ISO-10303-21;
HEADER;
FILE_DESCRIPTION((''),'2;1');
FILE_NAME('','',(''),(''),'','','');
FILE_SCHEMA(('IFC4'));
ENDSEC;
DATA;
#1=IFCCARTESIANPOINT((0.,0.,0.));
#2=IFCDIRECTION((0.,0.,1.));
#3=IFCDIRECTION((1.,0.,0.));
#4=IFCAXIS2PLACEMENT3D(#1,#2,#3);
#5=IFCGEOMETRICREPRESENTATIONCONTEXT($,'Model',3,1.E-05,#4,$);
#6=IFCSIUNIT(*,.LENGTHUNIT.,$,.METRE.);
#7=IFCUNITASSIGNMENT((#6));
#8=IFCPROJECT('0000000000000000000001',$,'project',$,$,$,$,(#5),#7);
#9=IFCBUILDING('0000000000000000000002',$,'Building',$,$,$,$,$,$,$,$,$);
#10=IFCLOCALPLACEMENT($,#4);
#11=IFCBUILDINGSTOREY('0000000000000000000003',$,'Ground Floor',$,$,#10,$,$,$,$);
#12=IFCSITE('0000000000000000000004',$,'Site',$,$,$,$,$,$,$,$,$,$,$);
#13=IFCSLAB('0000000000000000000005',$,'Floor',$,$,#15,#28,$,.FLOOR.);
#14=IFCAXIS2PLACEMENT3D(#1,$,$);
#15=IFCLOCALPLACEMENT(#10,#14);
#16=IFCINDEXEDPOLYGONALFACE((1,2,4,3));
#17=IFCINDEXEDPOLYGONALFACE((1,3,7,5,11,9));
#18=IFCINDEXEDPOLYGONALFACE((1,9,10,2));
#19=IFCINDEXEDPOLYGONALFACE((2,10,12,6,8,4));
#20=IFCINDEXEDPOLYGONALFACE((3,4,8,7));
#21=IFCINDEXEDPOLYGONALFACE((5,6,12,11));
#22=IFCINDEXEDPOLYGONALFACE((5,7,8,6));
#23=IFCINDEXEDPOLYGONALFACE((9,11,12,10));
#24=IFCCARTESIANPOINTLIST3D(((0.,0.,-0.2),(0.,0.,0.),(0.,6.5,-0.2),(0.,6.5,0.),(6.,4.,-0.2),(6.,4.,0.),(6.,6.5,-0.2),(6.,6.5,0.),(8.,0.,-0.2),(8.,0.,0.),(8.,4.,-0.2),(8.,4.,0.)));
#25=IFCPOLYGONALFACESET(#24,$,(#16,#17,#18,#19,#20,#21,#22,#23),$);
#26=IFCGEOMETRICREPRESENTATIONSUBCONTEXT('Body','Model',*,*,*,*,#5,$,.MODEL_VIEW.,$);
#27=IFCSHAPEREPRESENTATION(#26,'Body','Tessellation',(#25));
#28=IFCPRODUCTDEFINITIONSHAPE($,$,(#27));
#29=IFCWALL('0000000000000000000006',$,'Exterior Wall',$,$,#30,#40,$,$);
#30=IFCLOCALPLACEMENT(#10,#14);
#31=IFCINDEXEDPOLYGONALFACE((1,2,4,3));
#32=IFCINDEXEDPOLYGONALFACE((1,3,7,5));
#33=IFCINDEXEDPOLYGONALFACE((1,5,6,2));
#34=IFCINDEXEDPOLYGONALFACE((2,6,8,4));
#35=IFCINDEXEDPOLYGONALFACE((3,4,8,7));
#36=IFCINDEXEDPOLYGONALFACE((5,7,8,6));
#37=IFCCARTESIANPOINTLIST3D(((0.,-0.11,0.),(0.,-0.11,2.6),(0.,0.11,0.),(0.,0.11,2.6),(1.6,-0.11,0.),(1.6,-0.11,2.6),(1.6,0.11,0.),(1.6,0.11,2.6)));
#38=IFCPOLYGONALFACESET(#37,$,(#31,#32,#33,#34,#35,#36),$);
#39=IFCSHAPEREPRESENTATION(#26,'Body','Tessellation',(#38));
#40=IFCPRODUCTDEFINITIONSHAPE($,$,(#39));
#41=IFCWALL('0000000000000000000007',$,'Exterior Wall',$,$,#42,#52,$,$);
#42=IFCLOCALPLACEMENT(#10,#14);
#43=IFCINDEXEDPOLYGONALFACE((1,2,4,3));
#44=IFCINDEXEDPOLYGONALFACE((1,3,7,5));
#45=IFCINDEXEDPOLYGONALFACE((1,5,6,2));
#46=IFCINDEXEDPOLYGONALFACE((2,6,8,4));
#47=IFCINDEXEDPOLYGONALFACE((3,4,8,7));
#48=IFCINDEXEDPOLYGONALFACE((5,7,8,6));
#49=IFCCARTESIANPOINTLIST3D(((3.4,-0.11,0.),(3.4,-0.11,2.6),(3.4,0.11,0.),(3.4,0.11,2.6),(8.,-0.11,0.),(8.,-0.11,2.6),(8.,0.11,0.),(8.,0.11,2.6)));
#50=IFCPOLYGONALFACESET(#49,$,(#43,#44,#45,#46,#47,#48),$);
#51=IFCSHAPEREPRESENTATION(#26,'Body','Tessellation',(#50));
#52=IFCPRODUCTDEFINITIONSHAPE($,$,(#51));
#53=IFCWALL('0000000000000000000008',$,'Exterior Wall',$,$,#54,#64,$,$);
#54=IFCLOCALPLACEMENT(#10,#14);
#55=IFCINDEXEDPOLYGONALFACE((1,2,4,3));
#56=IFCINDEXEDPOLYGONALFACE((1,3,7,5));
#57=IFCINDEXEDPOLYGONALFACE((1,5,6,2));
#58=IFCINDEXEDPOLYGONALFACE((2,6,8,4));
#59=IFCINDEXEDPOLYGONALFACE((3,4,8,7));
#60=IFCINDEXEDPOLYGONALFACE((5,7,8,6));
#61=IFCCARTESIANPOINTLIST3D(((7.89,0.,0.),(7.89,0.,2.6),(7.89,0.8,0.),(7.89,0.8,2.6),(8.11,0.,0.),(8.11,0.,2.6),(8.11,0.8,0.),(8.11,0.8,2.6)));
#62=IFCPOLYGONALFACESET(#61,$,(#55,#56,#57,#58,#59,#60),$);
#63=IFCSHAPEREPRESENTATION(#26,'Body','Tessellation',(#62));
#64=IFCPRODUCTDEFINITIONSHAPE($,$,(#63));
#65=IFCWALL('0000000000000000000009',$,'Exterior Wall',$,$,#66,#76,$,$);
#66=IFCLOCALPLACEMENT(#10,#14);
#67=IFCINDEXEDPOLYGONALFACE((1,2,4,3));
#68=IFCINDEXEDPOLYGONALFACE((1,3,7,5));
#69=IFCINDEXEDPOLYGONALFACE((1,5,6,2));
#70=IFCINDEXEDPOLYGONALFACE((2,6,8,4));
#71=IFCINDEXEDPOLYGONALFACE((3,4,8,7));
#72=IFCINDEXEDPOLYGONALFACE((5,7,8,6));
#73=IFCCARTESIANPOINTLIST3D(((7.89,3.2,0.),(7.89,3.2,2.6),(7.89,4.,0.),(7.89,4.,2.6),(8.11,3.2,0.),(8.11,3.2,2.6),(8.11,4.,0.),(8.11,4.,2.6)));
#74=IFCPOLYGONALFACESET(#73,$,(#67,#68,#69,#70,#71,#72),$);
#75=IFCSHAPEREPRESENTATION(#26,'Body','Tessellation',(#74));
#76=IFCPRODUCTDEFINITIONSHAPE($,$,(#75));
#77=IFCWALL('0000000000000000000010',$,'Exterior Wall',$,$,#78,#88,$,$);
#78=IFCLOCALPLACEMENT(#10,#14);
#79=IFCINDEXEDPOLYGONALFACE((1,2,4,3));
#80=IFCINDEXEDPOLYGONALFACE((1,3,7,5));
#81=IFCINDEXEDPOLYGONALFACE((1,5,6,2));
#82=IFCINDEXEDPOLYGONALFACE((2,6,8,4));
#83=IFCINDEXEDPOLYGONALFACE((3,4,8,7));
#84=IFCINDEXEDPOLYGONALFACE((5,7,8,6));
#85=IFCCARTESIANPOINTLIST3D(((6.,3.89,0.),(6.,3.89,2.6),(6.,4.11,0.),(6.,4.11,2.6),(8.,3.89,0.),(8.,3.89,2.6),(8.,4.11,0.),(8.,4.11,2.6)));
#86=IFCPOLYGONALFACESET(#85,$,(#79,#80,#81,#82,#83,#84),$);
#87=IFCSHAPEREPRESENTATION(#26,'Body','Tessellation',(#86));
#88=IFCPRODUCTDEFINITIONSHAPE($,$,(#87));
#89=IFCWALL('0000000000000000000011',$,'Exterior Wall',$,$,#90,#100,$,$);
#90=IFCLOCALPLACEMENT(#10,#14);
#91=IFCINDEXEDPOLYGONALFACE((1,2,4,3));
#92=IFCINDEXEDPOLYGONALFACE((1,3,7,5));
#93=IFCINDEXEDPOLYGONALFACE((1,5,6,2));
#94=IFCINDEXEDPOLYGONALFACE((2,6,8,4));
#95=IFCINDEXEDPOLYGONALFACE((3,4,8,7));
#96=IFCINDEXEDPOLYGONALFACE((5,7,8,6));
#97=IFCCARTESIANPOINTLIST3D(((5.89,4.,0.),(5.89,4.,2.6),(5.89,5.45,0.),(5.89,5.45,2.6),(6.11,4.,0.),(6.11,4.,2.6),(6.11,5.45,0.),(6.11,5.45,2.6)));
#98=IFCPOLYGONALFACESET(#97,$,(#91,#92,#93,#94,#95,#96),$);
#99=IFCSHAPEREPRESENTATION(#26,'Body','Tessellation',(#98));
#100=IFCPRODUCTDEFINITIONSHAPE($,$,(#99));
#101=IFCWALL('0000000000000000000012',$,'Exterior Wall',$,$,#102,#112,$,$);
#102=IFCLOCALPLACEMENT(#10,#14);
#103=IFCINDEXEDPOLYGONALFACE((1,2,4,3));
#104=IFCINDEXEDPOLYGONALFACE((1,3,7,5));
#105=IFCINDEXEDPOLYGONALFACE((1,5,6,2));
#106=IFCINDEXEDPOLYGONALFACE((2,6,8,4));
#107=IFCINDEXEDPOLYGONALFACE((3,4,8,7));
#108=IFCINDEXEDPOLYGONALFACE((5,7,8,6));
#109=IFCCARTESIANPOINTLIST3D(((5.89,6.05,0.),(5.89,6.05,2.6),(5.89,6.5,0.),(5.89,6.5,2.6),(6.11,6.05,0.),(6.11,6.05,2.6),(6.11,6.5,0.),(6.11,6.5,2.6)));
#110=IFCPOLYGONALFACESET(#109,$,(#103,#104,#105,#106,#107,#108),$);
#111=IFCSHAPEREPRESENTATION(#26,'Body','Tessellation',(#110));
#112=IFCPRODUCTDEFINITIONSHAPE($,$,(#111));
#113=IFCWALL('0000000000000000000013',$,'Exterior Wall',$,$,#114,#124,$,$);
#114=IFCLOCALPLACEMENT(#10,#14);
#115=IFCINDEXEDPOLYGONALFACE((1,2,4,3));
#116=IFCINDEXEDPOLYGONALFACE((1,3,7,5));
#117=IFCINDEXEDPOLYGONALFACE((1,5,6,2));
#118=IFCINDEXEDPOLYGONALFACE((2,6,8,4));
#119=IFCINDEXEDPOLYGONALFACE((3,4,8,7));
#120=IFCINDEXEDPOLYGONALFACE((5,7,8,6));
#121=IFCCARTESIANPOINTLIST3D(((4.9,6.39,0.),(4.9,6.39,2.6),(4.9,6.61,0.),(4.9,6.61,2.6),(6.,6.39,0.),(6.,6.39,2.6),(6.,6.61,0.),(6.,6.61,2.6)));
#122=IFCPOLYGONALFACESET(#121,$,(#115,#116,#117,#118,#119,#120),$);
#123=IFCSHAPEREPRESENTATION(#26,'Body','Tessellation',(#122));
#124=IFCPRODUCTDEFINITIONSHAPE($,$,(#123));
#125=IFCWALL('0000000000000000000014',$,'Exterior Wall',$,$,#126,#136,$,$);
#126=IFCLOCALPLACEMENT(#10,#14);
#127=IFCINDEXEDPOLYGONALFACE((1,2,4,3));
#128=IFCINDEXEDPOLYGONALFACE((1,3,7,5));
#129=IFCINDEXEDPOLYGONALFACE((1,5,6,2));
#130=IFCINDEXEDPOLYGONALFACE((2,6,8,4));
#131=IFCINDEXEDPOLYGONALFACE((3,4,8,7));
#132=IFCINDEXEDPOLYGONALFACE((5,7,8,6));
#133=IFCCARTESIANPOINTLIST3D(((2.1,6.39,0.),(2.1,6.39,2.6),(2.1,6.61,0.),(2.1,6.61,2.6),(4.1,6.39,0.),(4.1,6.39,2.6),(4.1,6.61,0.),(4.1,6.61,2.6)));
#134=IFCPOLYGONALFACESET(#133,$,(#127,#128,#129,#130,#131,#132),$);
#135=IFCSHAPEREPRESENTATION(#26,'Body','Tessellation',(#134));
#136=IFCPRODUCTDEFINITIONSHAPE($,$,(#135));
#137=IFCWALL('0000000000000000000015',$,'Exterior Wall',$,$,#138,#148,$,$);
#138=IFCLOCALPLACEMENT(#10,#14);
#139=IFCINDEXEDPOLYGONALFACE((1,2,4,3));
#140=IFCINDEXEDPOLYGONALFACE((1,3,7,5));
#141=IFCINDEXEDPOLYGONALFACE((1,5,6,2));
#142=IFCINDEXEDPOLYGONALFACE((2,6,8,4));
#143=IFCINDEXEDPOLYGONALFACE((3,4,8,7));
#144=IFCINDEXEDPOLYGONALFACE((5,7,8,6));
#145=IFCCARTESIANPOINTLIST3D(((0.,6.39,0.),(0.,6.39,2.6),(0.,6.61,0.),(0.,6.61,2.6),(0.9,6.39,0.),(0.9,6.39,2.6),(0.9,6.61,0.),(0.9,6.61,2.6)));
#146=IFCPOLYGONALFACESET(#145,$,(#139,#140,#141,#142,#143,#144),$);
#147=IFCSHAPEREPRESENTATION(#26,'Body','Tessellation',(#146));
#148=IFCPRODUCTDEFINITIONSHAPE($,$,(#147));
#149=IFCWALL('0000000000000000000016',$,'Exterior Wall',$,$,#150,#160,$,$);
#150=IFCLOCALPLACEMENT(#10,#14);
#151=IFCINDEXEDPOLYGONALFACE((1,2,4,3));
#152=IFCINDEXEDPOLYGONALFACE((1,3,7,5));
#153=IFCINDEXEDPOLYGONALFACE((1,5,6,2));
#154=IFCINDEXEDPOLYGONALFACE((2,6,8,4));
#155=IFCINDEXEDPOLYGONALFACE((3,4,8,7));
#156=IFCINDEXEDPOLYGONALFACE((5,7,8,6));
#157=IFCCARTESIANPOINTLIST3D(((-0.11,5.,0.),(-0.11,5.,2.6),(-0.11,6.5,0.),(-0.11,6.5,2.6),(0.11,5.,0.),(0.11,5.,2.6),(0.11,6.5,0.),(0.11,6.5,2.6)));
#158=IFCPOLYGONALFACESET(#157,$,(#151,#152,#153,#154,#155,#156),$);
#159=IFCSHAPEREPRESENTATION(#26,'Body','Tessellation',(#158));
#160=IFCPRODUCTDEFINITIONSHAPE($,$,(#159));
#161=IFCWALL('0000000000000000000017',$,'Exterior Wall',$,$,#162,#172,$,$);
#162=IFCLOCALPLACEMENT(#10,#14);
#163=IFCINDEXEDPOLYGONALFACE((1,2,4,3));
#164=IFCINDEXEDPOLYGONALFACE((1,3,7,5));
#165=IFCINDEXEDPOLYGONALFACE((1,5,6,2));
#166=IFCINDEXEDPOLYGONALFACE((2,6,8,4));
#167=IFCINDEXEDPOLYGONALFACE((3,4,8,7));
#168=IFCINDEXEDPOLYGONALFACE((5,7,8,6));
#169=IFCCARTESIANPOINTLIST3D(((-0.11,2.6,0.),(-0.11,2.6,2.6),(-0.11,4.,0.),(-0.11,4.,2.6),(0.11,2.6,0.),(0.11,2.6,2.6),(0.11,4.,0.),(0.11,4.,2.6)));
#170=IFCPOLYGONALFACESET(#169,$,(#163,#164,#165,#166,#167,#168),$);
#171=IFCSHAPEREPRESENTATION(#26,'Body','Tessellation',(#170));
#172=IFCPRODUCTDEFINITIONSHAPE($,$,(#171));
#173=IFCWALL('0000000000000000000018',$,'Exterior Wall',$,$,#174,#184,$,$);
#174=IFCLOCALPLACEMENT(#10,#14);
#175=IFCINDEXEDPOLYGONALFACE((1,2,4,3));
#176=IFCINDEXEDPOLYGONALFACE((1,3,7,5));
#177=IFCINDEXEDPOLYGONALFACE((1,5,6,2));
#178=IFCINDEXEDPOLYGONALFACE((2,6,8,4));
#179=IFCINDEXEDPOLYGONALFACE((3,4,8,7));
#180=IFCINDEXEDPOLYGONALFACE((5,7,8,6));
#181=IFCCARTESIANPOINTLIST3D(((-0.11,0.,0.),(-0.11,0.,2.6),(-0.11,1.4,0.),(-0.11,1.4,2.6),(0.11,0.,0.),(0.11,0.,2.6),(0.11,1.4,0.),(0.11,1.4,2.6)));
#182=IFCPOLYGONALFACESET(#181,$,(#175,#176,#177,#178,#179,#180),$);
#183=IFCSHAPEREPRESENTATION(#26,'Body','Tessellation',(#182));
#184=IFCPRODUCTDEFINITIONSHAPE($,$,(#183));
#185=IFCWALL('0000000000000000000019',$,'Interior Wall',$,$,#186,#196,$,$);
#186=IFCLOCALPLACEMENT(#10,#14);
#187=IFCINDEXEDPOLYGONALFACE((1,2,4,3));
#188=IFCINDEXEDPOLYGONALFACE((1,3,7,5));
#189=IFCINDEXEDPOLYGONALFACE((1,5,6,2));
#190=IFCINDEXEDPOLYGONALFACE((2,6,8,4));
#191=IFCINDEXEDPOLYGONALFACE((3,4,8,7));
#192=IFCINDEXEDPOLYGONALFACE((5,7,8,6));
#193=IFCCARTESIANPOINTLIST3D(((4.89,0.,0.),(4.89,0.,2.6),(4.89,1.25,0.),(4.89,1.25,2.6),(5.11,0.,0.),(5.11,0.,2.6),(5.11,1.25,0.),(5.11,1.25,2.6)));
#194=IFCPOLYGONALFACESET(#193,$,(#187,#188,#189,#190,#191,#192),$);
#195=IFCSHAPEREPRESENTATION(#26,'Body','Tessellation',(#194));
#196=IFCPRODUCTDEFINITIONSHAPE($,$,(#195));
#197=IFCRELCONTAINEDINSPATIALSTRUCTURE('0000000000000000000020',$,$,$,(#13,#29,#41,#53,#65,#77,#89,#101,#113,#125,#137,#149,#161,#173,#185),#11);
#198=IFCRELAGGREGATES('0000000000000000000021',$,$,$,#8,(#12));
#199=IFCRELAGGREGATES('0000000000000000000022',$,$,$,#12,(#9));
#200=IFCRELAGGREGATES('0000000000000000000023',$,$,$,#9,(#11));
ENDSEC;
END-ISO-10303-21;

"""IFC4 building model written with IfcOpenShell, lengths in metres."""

from ifc_helpers import new_model, si_unit, frame, origin_with_axes, place, context, subcontext, project, spatial, indexed_curve, outline, extrude, element, save


model = new_model("IFC4")

# Units and contexts
model_context = context("Model", 3, precision=1e-05, world=origin_with_axes())
body_context = subcontext(model_context, "Body", "Model", "MODEL_VIEW")
ifc_project = project(units=[si_unit("LENGTHUNIT", "METRE")], contexts=[model_context])

# Site, building, storey
site = spatial("IfcSite", under=ifc_project, Name="Site")
building = spatial("IfcBuilding", under=site, Name="Building")
storey_placement = place(None, origin_with_axes())
storey = spatial("IfcBuildingStorey", under=building, at=storey_placement, Name="Ground Floor")

# Slab
slab_placement = place(storey_placement, frame((0.0, 0.0, -0.2), z_axis=(0.0, 0.0, 1.0), x_axis=(1.0, 0.0, 0.0)))
element("IfcSlab", 1, at=slab_placement, inside=storey, Name="Floor", PredefinedType="FLOOR", context=body_context, shape_type="SweptSolid", body=[
    extrude(outline(indexed_curve([(0.0, 0.0), (8.0, 0.0), (8.0, 4.0), (6.0, 4.0), (6.0, 6.5), (0.0, 6.5)])), None, (0.0, 0.0, 1.0), 0.2),
])

# Walls
wall_1_placement = place(storey_placement, origin_with_axes())
element("IfcWall", 2, at=wall_1_placement, inside=storey, Name="Exterior Wall", context=body_context, shape_type="SweptSolid", body=[
    extrude(outline(indexed_curve([(0.0, 0.0), (0.0, 0.22), (1.6, 0.22), (1.6, 0.0), (0.0, 0.0)], self_intersect=False)), frame((0.0, -0.11, 0.0), z_axis=(0.0, 0.0, 1.0), x_axis=(1.0, 0.0, 0.0)), (0.0, 0.0, 1.0), 2.6),
])
wall_2_placement = place(storey_placement, frame((3.4, 0.0, 0.0), z_axis=(0.0, 0.0, 1.0), x_axis=(1.0, 0.0, 0.0)))
element("IfcWall", 3, at=wall_2_placement, inside=storey, Name="Exterior Wall", context=body_context, shape_type="SweptSolid", body=[
    extrude(outline(indexed_curve([(0.0, 0.0), (0.0, 0.22), (4.6, 0.22), (4.6, 0.0), (0.0, 0.0)], self_intersect=False)), frame((0.0, -0.11, 0.0), z_axis=(0.0, 0.0, 1.0), x_axis=(1.0, 0.0, 0.0)), (0.0, 0.0, 1.0), 2.6),
])
wall_3_placement = place(storey_placement, frame((8.0, 0.0, 0.0), z_axis=(0.0, 0.0, 1.0), x_axis=(0.0, 1.0, 0.0)))
element("IfcWall", 4, at=wall_3_placement, inside=storey, Name="Exterior Wall", context=body_context, shape_type="SweptSolid", body=[
    extrude(outline(indexed_curve([(0.0, 0.0), (0.0, 0.22), (0.8, 0.22), (0.8, 0.0), (0.0, 0.0)], self_intersect=False)), frame((0.0, -0.11, 0.0), z_axis=(0.0, 0.0, 1.0), x_axis=(1.0, 0.0, 0.0)), (0.0, 0.0, 1.0), 2.6),
])
wall_4_placement = place(storey_placement, frame((8.0, 3.2, 0.0), z_axis=(0.0, 0.0, 1.0), x_axis=(0.0, 1.0, 0.0)))
element("IfcWall", 5, at=wall_4_placement, inside=storey, Name="Exterior Wall", context=body_context, shape_type="SweptSolid", body=[
    extrude(outline(indexed_curve([(0.0, 0.0), (0.0, 0.22), (0.8, 0.22), (0.8, 0.0), (0.0, 0.0)], self_intersect=False)), frame((0.0, -0.11, 0.0), z_axis=(0.0, 0.0, 1.0), x_axis=(1.0, 0.0, 0.0)), (0.0, 0.0, 1.0), 2.6),
])
wall_5_placement = place(storey_placement, frame((8.0, 4.0, 0.0), z_axis=(0.0, 0.0, 1.0), x_axis=(-1.0, 0.0, 0.0)))
element("IfcWall", 6, at=wall_5_placement, inside=storey, Name="Exterior Wall", context=body_context, shape_type="SweptSolid", body=[
    extrude(outline(indexed_curve([(0.0, 0.0), (0.0, 0.22), (2.0, 0.22), (2.0, 0.0), (0.0, 0.0)], self_intersect=False)), frame((0.0, -0.11, 0.0), z_axis=(0.0, 0.0, 1.0), x_axis=(1.0, 0.0, 0.0)), (0.0, 0.0, 1.0), 2.6),
])
wall_6_placement = place(storey_placement, frame((6.0, 4.0, 0.0), z_axis=(0.0, 0.0, 1.0), x_axis=(0.0, 1.0, 0.0)))
element("IfcWall", 7, at=wall_6_placement, inside=storey, Name="Exterior Wall", context=body_context, shape_type="SweptSolid", body=[
    extrude(outline(indexed_curve([(0.0, 0.0), (0.0, 0.22), (1.45, 0.22), (1.45, 0.0), (0.0, 0.0)], self_intersect=False)), frame((0.0, -0.11, 0.0), z_axis=(0.0, 0.0, 1.0), x_axis=(1.0, 0.0, 0.0)), (0.0, 0.0, 1.0), 2.6),
])
wall_7_placement = place(storey_placement, frame((6.0, 6.05, 0.0), z_axis=(0.0, 0.0, 1.0), x_axis=(0.0, 1.0, 0.0)))
element("IfcWall", 8, at=wall_7_placement, inside=storey, Name="Exterior Wall", context=body_context, shape_type="SweptSolid", body=[
    extrude(outline(indexed_curve([(0.0, 0.0), (0.0, 0.22), (0.45, 0.22), (0.45, 0.0), (0.0, 0.0)], self_intersect=False)), frame((0.0, -0.11, 0.0), z_axis=(0.0, 0.0, 1.0), x_axis=(1.0, 0.0, 0.0)), (0.0, 0.0, 1.0), 2.6),
])
wall_8_placement = place(storey_placement, frame((6.0, 6.5, 0.0), z_axis=(0.0, 0.0, 1.0), x_axis=(-1.0, 0.0, 0.0)))
element("IfcWall", 9, at=wall_8_placement, inside=storey, Name="Exterior Wall", context=body_context, shape_type="SweptSolid", body=[
    extrude(outline(indexed_curve([(0.0, 0.0), (0.0, 0.22), (1.1, 0.22), (1.1, 0.0), (0.0, 0.0)], self_intersect=False)), frame((0.0, -0.11, 0.0), z_axis=(0.0, 0.0, 1.0), x_axis=(1.0, 0.0, 0.0)), (0.0, 0.0, 1.0), 2.6),
])
wall_9_placement = place(storey_placement, frame((4.1, 6.5, 0.0), z_axis=(0.0, 0.0, 1.0), x_axis=(-1.0, 0.0, 0.0)))
element("IfcWall", 10, at=wall_9_placement, inside=storey, Name="Exterior Wall", context=body_context, shape_type="SweptSolid", body=[
    extrude(outline(indexed_curve([(0.0, 0.0), (0.0, 0.22), (2.0, 0.22), (2.0, 0.0), (0.0, 0.0)], self_intersect=False)), frame((0.0, -0.11, 0.0), z_axis=(0.0, 0.0, 1.0), x_axis=(1.0, 0.0, 0.0)), (0.0, 0.0, 1.0), 2.6),
])
wall_10_placement = place(storey_placement, frame((0.9, 6.5, 0.0), z_axis=(0.0, 0.0, 1.0), x_axis=(-1.0, 0.0, 0.0)))
element("IfcWall", 11, at=wall_10_placement, inside=storey, Name="Exterior Wall", context=body_context, shape_type="SweptSolid", body=[
    extrude(outline(indexed_curve([(0.0, 0.0), (0.0, 0.22), (0.9, 0.22), (0.9, 0.0), (0.0, 0.0)], self_intersect=False)), frame((0.0, -0.11, 0.0), z_axis=(0.0, 0.0, 1.0), x_axis=(1.0, 0.0, 0.0)), (0.0, 0.0, 1.0), 2.6),
])
wall_11_placement = place(storey_placement, frame((0.0, 6.5, 0.0), z_axis=(0.0, 0.0, 1.0), x_axis=(0.0, -1.0, 0.0)))
element("IfcWall", 12, at=wall_11_placement, inside=storey, Name="Exterior Wall", context=body_context, shape_type="SweptSolid", body=[
    extrude(outline(indexed_curve([(0.0, 0.0), (0.0, 0.22), (1.5, 0.22), (1.5, 0.0), (0.0, 0.0)], self_intersect=False)), frame((0.0, -0.11, 0.0), z_axis=(0.0, 0.0, 1.0), x_axis=(1.0, 0.0, 0.0)), (0.0, 0.0, 1.0), 2.6),
])
wall_12_placement = place(storey_placement, frame((0.0, 4.0, 0.0), z_axis=(0.0, 0.0, 1.0), x_axis=(0.0, -1.0, 0.0)))
element("IfcWall", 13, at=wall_12_placement, inside=storey, Name="Exterior Wall", context=body_context, shape_type="SweptSolid", body=[
    extrude(outline(indexed_curve([(0.0, 0.0), (0.0, 0.22), (1.4, 0.22), (1.4, 0.0), (0.0, 0.0)], self_intersect=False)), frame((0.0, -0.11, 0.0), z_axis=(0.0, 0.0, 1.0), x_axis=(1.0, 0.0, 0.0)), (0.0, 0.0, 1.0), 2.6),
])
wall_13_placement = place(storey_placement, frame((0.0, 1.4, 0.0), z_axis=(0.0, 0.0, 1.0), x_axis=(0.0, -1.0, 0.0)))
element("IfcWall", 14, at=wall_13_placement, inside=storey, Name="Exterior Wall", context=body_context, shape_type="SweptSolid", body=[
    extrude(outline(indexed_curve([(0.0, 0.0), (0.0, 0.22), (1.4, 0.22), (1.4, 0.0), (0.0, 0.0)], self_intersect=False)), frame((0.0, -0.11, 0.0), z_axis=(0.0, 0.0, 1.0), x_axis=(1.0, 0.0, 0.0)), (0.0, 0.0, 1.0), 2.6),
])
for number, where, z_axis, x_axis, name in (
    (15, (5.0, 0.0, 0.0), (0.0, 0.0, 1.0), (0.0, 1.0, 0.0), "Interior Wall"),
):
    element("IfcWall", number, at=place(storey_placement, frame(where, z_axis=z_axis, x_axis=x_axis)), inside=storey, Name=name, context=body_context, shape_type="SweptSolid", body=[
        extrude(outline(indexed_curve([(0.0, 0.0), (0.0, 0.22), (1.25, 0.22), (1.25, 0.0), (0.0, 0.0)], self_intersect=False)), frame((0.0, -0.11, 0.0), z_axis=(0.0, 0.0, 1.0), x_axis=(1.0, 0.0, 0.0)), (0.0, 0.0, 1.0), 2.6),
    ])

save(model, "model.ifc")
